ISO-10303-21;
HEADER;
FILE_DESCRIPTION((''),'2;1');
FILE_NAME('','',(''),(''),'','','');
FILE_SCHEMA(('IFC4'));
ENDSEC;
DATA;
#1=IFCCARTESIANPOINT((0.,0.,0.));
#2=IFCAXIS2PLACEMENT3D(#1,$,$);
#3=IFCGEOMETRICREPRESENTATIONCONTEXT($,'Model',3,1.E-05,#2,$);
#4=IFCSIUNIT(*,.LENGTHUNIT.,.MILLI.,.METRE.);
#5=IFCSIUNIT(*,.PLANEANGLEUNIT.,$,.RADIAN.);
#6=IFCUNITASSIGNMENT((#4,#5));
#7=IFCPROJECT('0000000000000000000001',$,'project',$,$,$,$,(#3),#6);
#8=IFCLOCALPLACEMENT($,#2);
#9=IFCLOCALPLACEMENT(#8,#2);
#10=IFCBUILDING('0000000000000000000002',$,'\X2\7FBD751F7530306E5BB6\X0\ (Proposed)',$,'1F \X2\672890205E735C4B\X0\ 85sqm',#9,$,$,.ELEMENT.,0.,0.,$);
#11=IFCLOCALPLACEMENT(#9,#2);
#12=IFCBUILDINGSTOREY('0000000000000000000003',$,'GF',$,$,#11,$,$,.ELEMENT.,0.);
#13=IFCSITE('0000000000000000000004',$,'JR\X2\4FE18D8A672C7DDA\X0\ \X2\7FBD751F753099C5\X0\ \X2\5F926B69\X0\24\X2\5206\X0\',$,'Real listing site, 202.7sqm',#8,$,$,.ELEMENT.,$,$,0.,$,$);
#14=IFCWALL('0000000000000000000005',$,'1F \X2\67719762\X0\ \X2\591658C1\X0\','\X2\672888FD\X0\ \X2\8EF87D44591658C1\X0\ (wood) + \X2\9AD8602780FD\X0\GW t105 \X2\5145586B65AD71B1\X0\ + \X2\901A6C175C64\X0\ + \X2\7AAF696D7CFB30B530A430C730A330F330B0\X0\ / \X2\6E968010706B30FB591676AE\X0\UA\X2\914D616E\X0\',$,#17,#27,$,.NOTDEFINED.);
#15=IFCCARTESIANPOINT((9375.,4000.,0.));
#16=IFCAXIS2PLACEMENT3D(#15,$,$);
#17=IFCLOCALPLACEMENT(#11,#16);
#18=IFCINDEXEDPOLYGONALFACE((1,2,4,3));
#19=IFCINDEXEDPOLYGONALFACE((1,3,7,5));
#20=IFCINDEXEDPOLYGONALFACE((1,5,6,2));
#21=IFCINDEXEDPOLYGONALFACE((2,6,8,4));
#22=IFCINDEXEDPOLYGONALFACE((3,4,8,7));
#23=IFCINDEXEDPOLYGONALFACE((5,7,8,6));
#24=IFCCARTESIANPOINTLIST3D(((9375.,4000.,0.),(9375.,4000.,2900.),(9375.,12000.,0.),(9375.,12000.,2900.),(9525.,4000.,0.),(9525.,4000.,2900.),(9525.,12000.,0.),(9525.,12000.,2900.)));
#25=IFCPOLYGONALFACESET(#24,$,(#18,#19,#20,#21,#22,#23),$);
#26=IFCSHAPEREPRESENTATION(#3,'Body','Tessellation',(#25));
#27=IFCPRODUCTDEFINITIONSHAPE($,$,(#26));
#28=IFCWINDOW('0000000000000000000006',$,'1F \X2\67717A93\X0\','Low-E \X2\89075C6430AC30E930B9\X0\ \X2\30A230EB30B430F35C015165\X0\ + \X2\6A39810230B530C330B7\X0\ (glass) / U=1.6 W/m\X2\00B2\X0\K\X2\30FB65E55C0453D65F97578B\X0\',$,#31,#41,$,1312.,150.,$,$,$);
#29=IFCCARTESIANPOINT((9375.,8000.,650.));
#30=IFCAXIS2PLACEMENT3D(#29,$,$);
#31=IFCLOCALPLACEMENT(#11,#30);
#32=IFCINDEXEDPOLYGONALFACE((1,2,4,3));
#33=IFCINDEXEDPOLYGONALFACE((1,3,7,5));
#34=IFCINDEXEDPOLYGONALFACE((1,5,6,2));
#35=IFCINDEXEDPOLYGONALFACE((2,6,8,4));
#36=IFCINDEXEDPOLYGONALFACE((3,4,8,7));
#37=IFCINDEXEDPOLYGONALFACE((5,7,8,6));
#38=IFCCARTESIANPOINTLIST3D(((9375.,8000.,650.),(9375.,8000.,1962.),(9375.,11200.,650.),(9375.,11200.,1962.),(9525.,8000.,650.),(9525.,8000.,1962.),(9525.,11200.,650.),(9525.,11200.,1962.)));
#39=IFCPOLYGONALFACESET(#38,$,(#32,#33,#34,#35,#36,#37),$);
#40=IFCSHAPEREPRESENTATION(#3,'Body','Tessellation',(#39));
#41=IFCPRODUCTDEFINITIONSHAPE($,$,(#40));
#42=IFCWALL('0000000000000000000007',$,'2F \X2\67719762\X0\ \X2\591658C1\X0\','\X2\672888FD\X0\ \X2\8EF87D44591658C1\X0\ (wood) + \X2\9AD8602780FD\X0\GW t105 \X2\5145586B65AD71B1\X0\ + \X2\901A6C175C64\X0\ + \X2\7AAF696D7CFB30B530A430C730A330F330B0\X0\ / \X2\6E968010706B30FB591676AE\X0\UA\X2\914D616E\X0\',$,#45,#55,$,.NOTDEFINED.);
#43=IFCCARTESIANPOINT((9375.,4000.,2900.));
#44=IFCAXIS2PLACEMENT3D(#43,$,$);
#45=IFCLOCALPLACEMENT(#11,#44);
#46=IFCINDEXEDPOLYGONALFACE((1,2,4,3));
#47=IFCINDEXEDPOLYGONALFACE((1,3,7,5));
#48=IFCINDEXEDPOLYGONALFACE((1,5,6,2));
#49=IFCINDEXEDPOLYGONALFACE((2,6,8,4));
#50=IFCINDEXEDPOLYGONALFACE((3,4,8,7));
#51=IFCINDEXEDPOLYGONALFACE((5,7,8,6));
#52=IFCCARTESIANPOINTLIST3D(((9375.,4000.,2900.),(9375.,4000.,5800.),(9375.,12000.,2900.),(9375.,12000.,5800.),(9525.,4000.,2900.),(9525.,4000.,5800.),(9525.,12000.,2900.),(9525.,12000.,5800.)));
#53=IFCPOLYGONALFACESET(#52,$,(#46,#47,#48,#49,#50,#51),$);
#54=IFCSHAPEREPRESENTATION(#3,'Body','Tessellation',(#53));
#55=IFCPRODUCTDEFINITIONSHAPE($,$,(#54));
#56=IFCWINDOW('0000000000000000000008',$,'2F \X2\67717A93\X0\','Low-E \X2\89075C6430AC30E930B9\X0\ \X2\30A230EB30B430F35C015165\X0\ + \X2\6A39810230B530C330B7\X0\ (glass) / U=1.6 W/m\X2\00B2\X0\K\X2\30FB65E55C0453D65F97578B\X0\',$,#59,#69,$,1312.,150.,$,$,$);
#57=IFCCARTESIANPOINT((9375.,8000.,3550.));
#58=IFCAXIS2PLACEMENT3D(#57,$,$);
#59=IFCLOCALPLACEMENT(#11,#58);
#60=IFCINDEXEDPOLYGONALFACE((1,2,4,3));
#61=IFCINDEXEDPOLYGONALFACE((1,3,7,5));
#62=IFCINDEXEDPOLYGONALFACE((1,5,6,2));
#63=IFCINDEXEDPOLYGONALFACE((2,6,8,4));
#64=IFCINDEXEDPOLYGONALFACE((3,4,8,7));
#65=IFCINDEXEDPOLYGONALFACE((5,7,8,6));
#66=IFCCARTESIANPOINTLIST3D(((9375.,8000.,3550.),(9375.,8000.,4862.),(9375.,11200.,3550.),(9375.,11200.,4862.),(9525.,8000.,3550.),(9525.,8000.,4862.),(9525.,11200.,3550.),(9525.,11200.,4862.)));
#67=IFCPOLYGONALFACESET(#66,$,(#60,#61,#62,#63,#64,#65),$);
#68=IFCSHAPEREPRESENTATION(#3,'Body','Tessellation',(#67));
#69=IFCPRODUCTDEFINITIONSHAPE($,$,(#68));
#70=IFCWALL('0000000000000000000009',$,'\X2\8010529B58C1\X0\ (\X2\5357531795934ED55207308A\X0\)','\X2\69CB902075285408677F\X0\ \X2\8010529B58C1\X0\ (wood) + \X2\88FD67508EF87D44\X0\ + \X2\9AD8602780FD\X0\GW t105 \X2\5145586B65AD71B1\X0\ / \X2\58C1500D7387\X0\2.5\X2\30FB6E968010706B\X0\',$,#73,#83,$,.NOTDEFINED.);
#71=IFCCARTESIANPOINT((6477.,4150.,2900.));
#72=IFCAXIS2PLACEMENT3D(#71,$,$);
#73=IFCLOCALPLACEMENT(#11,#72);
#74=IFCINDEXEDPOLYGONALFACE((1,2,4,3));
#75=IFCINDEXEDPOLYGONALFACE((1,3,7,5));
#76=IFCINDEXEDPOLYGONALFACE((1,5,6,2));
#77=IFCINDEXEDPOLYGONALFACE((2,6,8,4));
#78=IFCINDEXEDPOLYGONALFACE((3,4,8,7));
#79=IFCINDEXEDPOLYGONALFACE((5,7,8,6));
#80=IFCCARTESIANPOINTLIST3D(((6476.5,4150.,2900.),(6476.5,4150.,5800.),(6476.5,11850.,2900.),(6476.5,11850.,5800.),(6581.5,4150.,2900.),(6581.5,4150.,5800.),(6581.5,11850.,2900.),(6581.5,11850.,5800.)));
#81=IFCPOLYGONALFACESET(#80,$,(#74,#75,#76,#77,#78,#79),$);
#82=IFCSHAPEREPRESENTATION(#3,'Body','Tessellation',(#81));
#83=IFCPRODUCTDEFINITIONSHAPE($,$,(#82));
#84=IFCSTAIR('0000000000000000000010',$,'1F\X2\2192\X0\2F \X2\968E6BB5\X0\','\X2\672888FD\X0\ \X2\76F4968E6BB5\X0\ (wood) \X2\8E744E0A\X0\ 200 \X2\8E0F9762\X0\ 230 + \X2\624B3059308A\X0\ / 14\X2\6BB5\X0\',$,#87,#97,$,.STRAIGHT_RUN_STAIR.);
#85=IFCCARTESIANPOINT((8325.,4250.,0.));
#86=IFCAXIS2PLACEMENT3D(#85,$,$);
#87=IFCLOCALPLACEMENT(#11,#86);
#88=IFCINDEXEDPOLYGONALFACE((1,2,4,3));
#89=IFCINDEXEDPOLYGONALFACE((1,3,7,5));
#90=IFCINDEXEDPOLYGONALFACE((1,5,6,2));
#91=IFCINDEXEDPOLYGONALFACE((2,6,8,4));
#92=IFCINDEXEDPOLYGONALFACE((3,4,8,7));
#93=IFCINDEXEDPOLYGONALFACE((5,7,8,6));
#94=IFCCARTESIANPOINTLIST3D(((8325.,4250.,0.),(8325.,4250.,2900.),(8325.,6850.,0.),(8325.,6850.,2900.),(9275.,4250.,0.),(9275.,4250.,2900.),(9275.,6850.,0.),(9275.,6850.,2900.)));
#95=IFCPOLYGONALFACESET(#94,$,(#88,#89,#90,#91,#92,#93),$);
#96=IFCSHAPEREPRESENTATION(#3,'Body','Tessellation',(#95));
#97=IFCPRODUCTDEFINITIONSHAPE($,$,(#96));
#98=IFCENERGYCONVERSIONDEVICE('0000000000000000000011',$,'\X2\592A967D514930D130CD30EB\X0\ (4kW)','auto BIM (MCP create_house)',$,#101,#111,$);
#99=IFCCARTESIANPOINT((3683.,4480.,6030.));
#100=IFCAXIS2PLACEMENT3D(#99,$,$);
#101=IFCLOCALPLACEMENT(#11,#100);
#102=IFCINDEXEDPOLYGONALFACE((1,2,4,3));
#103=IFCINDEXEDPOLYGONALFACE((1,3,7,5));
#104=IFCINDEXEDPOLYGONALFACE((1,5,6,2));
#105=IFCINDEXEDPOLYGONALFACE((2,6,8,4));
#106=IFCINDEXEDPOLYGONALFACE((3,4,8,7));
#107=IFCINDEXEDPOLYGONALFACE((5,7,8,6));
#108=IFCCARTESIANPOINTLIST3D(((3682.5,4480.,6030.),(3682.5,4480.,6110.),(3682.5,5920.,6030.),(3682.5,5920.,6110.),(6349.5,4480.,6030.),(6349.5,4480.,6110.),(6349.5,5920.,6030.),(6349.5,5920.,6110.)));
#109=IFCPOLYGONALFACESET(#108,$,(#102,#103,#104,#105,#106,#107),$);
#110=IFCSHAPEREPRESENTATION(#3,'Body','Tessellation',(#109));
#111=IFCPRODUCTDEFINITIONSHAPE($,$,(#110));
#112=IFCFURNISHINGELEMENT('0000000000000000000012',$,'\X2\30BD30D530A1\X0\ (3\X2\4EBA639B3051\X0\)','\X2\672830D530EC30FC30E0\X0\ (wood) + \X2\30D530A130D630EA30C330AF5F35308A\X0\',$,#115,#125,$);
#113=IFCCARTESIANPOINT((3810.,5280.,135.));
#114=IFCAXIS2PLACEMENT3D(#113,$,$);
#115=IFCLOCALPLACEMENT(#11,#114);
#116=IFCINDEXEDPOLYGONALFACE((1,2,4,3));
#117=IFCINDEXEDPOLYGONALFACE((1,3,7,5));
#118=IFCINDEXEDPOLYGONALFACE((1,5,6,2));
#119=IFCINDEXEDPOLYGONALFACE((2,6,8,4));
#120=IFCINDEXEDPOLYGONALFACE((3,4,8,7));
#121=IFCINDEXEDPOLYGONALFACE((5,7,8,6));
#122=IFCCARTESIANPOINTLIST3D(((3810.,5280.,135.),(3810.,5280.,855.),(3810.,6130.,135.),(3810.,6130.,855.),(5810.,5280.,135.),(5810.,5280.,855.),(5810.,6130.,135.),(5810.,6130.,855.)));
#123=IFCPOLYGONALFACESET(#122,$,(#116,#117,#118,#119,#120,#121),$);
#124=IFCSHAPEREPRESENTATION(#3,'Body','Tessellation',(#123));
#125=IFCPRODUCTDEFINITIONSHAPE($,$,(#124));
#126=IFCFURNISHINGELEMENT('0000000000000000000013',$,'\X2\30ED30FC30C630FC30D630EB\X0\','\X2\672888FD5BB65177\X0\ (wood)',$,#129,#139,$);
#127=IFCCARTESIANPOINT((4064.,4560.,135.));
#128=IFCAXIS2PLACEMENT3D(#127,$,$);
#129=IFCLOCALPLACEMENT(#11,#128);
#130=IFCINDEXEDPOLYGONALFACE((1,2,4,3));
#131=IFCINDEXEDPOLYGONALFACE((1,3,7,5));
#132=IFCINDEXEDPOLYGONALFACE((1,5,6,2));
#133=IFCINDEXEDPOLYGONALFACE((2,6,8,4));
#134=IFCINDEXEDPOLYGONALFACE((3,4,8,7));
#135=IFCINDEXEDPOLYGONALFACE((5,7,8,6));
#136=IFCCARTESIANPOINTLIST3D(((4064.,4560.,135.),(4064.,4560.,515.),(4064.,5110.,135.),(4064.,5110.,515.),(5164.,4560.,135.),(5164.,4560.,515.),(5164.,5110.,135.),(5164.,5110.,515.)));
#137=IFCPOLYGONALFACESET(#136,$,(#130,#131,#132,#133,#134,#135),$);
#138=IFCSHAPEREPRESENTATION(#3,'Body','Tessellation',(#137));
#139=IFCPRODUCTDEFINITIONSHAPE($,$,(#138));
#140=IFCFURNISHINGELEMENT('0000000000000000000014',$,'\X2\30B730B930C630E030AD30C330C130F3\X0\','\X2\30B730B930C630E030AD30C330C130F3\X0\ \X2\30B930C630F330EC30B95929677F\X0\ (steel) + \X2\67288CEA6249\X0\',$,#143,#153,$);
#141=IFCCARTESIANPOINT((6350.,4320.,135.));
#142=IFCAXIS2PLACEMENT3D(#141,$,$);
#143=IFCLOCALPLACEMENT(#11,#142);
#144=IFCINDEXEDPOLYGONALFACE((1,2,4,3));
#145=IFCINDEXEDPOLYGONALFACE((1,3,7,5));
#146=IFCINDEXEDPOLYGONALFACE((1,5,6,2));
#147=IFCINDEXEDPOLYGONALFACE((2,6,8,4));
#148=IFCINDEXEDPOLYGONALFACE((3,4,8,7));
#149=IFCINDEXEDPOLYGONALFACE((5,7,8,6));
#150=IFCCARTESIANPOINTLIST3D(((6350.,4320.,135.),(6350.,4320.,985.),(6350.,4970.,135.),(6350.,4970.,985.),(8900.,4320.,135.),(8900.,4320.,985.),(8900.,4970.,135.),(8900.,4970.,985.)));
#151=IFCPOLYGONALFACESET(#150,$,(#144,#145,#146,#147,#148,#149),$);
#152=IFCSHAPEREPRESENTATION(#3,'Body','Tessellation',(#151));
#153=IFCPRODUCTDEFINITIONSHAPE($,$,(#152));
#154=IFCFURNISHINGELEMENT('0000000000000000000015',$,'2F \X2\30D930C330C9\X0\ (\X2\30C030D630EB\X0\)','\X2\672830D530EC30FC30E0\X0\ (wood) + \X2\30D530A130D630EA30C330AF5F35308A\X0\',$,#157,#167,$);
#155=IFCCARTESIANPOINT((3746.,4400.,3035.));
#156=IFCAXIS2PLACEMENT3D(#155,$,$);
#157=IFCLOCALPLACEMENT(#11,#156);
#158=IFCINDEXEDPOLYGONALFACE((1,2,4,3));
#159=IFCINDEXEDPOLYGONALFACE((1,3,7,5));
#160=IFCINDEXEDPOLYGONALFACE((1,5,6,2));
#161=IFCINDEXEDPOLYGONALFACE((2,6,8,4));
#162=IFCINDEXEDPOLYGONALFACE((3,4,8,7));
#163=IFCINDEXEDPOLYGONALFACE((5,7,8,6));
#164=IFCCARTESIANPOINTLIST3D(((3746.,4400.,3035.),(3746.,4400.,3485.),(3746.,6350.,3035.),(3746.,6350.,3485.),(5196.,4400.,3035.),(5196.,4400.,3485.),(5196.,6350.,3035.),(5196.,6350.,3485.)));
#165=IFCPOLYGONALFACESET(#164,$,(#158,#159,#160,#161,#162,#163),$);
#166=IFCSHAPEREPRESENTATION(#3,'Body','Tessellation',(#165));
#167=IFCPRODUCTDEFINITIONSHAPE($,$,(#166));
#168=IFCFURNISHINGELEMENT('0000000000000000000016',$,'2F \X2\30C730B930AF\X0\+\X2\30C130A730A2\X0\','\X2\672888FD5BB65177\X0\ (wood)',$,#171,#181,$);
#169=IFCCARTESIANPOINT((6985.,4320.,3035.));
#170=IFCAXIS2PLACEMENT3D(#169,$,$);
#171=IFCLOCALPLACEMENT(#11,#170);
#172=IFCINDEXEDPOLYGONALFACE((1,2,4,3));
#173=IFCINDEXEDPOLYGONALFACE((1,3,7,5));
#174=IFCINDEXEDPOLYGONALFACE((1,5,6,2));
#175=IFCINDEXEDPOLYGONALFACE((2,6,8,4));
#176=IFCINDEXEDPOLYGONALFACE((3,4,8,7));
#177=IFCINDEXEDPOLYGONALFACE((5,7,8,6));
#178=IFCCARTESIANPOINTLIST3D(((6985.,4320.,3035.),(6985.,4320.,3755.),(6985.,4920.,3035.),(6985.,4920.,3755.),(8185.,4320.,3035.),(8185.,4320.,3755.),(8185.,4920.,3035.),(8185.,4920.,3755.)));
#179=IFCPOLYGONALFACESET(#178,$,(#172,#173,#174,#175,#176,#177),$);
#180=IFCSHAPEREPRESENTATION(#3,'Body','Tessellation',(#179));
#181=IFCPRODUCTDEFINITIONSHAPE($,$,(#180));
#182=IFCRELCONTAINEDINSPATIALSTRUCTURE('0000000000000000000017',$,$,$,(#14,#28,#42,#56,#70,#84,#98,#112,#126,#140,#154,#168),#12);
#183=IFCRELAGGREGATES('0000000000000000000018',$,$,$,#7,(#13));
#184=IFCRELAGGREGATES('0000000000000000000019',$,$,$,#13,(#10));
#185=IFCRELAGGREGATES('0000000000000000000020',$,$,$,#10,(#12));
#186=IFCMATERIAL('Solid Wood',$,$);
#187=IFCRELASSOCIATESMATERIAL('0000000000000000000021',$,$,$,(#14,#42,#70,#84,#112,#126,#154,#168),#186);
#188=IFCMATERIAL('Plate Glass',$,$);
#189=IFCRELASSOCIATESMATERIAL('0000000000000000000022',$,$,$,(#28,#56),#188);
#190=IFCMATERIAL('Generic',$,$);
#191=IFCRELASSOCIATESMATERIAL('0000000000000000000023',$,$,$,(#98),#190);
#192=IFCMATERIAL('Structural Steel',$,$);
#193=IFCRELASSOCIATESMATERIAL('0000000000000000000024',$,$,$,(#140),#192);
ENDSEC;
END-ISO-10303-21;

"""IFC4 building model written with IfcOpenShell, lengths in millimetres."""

from ifc_helpers import new_model, si_unit, frame, frame_2d, origin, place, context, project, spatial, rectangle, extrude, material, element, fill, save


model = new_model("IFC4")

# Units and contexts
model_context = context("Model", 3, precision=1e-05, world=origin())
ifc_project = project(units=[si_unit("LENGTHUNIT", "METRE", prefix="MILLI"), si_unit("PLANEANGLEUNIT", "RADIAN")], contexts=[model_context])

# Site, building, storey
site_placement = place(None, origin())
site = spatial("IfcSite", under=ifc_project, at=site_placement, Name="JR信越本線 羽生田駅 徒歩24分", ObjectType="Real listing site, 202.7sqm", CompositionType="ELEMENT", RefElevation=0.0)
building_placement = place(site_placement, origin())
building = spatial("IfcBuilding", under=site, at=building_placement, Name="羽生田の家 (Proposed)", ObjectType="1F 木造平屋 85sqm", CompositionType="ELEMENT", ElevationOfRefHeight=0.0, ElevationOfTerrain=0.0)
storey_placement = place(building_placement, origin())
storey = spatial("IfcBuildingStorey", under=building, at=storey_placement, Name="GF", CompositionType="ELEMENT", Elevation=0.0)

# Wall, opening, window
ifc_material_1 = material(Name="Solid Wood")
wall_1_placement = place(storey_placement, frame((9375.0, 4000.0, 0.0)))
wall_1 = element("IfcWall", 1, at=wall_1_placement, inside=storey, material=ifc_material_1, Name="1F 東面 外壁", Description="木製 軸組外壁 (wood) + 高性能GW t105 充填断熱 + 通気層 + 窯業系サイディング / 準耐火・外皮UA配慮", PredefinedType="NOTDEFINED", context=model_context, shape_type="SweptSolid", body=[
    extrude(rectangle(XDim=150.0, YDim=8000.0, at=frame_2d((75.0, 4000.0))), frame((9375.0, 4000.0, 0.0)), (0.0, 0.0, 1.0), 2900.0),
])
opening_1_placement = place(storey_placement, frame((9375.0, 8000.0, 650.0)))
opening_1 = element("IfcOpeningElement", 2, at=opening_1_placement, cuts=wall_1, PredefinedType="NOTDEFINED", context=model_context, shape_type="SweptSolid", body=[
    extrude(rectangle(XDim=150.0, YDim=3200.0, at=frame_2d((75.0, 1600.0))), frame((9375.0, 8000.0, 650.0)), (0.0, 0.0, 1.0), 1312.0),
])
ifc_material_2 = material(Name="Plate Glass")
window_1_placement = place(storey_placement, frame((9375.0, 8000.0, 650.0)))
window_1 = element("IfcWindow", 3, at=window_1_placement, inside=storey, material=ifc_material_2, Name="1F 東窓", Description="Low-E 複層ガラス アルゴン封入 + 樹脂サッシ (glass) / U=1.6 W/m²K・日射取得型", OverallHeight=1312.0, OverallWidth=150.0, context=model_context, shape_type="SweptSolid", body=[
    extrude(rectangle(XDim=150.0, YDim=3200.0, at=frame_2d((75.0, 1600.0))), frame((9375.0, 8000.0, 650.0)), (0.0, 0.0, 1.0), 1312.0),
])
fill(opening_1, window_1)

# Wall, opening, window
wall_2_placement = place(storey_placement, frame((9375.0, 4000.0, 2900.0)))
wall_2 = element("IfcWall", 4, at=wall_2_placement, inside=storey, material=ifc_material_1, Name="2F 東面 外壁", Description="木製 軸組外壁 (wood) + 高性能GW t105 充填断熱 + 通気層 + 窯業系サイディング / 準耐火・外皮UA配慮", PredefinedType="NOTDEFINED", context=model_context, shape_type="SweptSolid", body=[
    extrude(rectangle(XDim=150.0, YDim=8000.0, at=frame_2d((75.0, 4000.0))), frame((9375.0, 4000.0, 2900.0)), (0.0, 0.0, 1.0), 2900.0),
])
opening_2_placement = place(storey_placement, frame((9375.0, 8000.0, 3550.0)))
opening_2 = element("IfcOpeningElement", 5, at=opening_2_placement, cuts=wall_2, PredefinedType="NOTDEFINED", context=model_context, shape_type="SweptSolid", body=[
    extrude(rectangle(XDim=150.0, YDim=3200.0, at=frame_2d((75.0, 1600.0))), frame((9375.0, 8000.0, 3550.0)), (0.0, 0.0, 1.0), 1312.0),
])
window_2_placement = place(storey_placement, frame((9375.0, 8000.0, 3550.0)))
window_2 = element("IfcWindow", 6, at=window_2_placement, inside=storey, material=ifc_material_2, Name="2F 東窓", Description="Low-E 複層ガラス アルゴン封入 + 樹脂サッシ (glass) / U=1.6 W/m²K・日射取得型", OverallHeight=1312.0, OverallWidth=150.0, context=model_context, shape_type="SweptSolid", body=[
    extrude(rectangle(XDim=150.0, YDim=3200.0, at=frame_2d((75.0, 1600.0))), frame((9375.0, 8000.0, 3550.0)), (0.0, 0.0, 1.0), 1312.0),
])
fill(opening_2, window_2)

# Wall
wall_3_placement = place(storey_placement, frame((6477.0, 4150.0, 2900.0)))
element("IfcWall", 7, at=wall_3_placement, inside=storey, material=ifc_material_1, Name="耐力壁 (南北間仕切り)", Description="構造用合板 耐力壁 (wood) + 製材軸組 + 高性能GW t105 充填断熱 / 壁倍率2.5・準耐火", PredefinedType="NOTDEFINED", context=model_context, shape_type="SweptSolid", body=[
    extrude(rectangle(XDim=105.0, YDim=7700.0, at=frame_2d((52.0, 3850.0))), frame((6477.0, 4150.0, 2900.0)), (0.0, 0.0, 1.0), 2900.0),
])

# Stair
stair_placement = place(storey_placement, frame((8325.0, 4250.0, 0.0)))
element("IfcStair", 8, at=stair_placement, inside=storey, material=ifc_material_1, Name="1F→2F 階段", Description="木製 直階段 (wood) 蹴上 200 踏面 230 + 手すり / 14段", PredefinedType="STRAIGHT_RUN_STAIR", context=model_context, shape_type="SweptSolid", body=[
    extrude(rectangle(XDim=950.0, YDim=2600.0, at=frame_2d((475.0, 1300.0))), frame((8325.0, 4250.0, 0.0)), (0.0, 0.0, 1.0), 2900.0),
])

# Energy conversion device
ifc_material_3 = material(Name="Generic")
energy_conversion_device_placement = place(storey_placement, frame((3683.0, 4480.0, 6030.0)))
element("IfcEnergyConversionDevice", 9, at=energy_conversion_device_placement, inside=storey, material=ifc_material_3, Name="太陽光パネル (4kW)", Description="auto BIM (MCP create_house)", context=model_context, shape_type="SweptSolid", body=[
    extrude(rectangle(XDim=2667.0, YDim=1440.0, at=frame_2d((1333.0, 720.0))), frame((3683.0, 4480.0, 6030.0)), (0.0, 0.0, 1.0), 80.0),
])

# Furnishing elements
furnishing_1_placement = place(storey_placement, frame((3810.0, 5280.0, 135.0)))
element("IfcFurnishingElement", 10, at=furnishing_1_placement, inside=storey, material=ifc_material_1, Name="ソファ (3人掛け)", Description="木フレーム (wood) + ファブリック張り", context=model_context, shape_type="SweptSolid", body=[
    extrude(rectangle(XDim=2000.0, YDim=850.0, at=frame_2d((1000.0, 425.0))), frame((3810.0, 5280.0, 135.0)), (0.0, 0.0, 1.0), 720.0),
])
furnishing_2_placement = place(storey_placement, frame((4064.0, 4560.0, 135.0)))
element("IfcFurnishingElement", 11, at=furnishing_2_placement, inside=storey, material=ifc_material_1, Name="ローテーブル", Description="木製家具 (wood)", context=model_context, shape_type="SweptSolid", body=[
    extrude(rectangle(XDim=1100.0, YDim=550.0, at=frame_2d((550.0, 275.0))), frame((4064.0, 4560.0, 135.0)), (0.0, 0.0, 1.0), 380.0),
])
ifc_material_4 = material(Name="Structural Steel")
furnishing_3_placement = place(storey_placement, frame((6350.0, 4320.0, 135.0)))
element("IfcFurnishingElement", 12, at=furnishing_3_placement, inside=storey, material=ifc_material_4, Name="システムキッチン", Description="システムキッチン ステンレス天板 (steel) + 木質扉", context=model_context, shape_type="SweptSolid", body=[
    extrude(rectangle(XDim=2550.0, YDim=650.0, at=frame_2d((1275.0, 325.0))), frame((6350.0, 4320.0, 135.0)), (0.0, 0.0, 1.0), 850.0),
])
furnishing_4_placement = place(storey_placement, frame((3746.0, 4400.0, 3035.0)))
element("IfcFurnishingElement", 13, at=furnishing_4_placement, inside=storey, material=ifc_material_1, Name="2F ベッド (ダブル)", Description="木フレーム (wood) + ファブリック張り", context=model_context, shape_type="SweptSolid", body=[
    extrude(rectangle(XDim=1450.0, YDim=1950.0, at=frame_2d((725.0, 975.0))), frame((3746.0, 4400.0, 3035.0)), (0.0, 0.0, 1.0), 450.0),
])
furnishing_5_placement = place(storey_placement, frame((6985.0, 4320.0, 3035.0)))
element("IfcFurnishingElement", 14, at=furnishing_5_placement, inside=storey, material=ifc_material_1, Name="2F デスク+チェア", Description="木製家具 (wood)", context=model_context, shape_type="SweptSolid", body=[
    extrude(rectangle(XDim=1200.0, YDim=600.0, at=frame_2d((600.0, 300.0))), frame((6985.0, 4320.0, 3035.0)), (0.0, 0.0, 1.0), 720.0),
])

save(model, "model.ifc")
